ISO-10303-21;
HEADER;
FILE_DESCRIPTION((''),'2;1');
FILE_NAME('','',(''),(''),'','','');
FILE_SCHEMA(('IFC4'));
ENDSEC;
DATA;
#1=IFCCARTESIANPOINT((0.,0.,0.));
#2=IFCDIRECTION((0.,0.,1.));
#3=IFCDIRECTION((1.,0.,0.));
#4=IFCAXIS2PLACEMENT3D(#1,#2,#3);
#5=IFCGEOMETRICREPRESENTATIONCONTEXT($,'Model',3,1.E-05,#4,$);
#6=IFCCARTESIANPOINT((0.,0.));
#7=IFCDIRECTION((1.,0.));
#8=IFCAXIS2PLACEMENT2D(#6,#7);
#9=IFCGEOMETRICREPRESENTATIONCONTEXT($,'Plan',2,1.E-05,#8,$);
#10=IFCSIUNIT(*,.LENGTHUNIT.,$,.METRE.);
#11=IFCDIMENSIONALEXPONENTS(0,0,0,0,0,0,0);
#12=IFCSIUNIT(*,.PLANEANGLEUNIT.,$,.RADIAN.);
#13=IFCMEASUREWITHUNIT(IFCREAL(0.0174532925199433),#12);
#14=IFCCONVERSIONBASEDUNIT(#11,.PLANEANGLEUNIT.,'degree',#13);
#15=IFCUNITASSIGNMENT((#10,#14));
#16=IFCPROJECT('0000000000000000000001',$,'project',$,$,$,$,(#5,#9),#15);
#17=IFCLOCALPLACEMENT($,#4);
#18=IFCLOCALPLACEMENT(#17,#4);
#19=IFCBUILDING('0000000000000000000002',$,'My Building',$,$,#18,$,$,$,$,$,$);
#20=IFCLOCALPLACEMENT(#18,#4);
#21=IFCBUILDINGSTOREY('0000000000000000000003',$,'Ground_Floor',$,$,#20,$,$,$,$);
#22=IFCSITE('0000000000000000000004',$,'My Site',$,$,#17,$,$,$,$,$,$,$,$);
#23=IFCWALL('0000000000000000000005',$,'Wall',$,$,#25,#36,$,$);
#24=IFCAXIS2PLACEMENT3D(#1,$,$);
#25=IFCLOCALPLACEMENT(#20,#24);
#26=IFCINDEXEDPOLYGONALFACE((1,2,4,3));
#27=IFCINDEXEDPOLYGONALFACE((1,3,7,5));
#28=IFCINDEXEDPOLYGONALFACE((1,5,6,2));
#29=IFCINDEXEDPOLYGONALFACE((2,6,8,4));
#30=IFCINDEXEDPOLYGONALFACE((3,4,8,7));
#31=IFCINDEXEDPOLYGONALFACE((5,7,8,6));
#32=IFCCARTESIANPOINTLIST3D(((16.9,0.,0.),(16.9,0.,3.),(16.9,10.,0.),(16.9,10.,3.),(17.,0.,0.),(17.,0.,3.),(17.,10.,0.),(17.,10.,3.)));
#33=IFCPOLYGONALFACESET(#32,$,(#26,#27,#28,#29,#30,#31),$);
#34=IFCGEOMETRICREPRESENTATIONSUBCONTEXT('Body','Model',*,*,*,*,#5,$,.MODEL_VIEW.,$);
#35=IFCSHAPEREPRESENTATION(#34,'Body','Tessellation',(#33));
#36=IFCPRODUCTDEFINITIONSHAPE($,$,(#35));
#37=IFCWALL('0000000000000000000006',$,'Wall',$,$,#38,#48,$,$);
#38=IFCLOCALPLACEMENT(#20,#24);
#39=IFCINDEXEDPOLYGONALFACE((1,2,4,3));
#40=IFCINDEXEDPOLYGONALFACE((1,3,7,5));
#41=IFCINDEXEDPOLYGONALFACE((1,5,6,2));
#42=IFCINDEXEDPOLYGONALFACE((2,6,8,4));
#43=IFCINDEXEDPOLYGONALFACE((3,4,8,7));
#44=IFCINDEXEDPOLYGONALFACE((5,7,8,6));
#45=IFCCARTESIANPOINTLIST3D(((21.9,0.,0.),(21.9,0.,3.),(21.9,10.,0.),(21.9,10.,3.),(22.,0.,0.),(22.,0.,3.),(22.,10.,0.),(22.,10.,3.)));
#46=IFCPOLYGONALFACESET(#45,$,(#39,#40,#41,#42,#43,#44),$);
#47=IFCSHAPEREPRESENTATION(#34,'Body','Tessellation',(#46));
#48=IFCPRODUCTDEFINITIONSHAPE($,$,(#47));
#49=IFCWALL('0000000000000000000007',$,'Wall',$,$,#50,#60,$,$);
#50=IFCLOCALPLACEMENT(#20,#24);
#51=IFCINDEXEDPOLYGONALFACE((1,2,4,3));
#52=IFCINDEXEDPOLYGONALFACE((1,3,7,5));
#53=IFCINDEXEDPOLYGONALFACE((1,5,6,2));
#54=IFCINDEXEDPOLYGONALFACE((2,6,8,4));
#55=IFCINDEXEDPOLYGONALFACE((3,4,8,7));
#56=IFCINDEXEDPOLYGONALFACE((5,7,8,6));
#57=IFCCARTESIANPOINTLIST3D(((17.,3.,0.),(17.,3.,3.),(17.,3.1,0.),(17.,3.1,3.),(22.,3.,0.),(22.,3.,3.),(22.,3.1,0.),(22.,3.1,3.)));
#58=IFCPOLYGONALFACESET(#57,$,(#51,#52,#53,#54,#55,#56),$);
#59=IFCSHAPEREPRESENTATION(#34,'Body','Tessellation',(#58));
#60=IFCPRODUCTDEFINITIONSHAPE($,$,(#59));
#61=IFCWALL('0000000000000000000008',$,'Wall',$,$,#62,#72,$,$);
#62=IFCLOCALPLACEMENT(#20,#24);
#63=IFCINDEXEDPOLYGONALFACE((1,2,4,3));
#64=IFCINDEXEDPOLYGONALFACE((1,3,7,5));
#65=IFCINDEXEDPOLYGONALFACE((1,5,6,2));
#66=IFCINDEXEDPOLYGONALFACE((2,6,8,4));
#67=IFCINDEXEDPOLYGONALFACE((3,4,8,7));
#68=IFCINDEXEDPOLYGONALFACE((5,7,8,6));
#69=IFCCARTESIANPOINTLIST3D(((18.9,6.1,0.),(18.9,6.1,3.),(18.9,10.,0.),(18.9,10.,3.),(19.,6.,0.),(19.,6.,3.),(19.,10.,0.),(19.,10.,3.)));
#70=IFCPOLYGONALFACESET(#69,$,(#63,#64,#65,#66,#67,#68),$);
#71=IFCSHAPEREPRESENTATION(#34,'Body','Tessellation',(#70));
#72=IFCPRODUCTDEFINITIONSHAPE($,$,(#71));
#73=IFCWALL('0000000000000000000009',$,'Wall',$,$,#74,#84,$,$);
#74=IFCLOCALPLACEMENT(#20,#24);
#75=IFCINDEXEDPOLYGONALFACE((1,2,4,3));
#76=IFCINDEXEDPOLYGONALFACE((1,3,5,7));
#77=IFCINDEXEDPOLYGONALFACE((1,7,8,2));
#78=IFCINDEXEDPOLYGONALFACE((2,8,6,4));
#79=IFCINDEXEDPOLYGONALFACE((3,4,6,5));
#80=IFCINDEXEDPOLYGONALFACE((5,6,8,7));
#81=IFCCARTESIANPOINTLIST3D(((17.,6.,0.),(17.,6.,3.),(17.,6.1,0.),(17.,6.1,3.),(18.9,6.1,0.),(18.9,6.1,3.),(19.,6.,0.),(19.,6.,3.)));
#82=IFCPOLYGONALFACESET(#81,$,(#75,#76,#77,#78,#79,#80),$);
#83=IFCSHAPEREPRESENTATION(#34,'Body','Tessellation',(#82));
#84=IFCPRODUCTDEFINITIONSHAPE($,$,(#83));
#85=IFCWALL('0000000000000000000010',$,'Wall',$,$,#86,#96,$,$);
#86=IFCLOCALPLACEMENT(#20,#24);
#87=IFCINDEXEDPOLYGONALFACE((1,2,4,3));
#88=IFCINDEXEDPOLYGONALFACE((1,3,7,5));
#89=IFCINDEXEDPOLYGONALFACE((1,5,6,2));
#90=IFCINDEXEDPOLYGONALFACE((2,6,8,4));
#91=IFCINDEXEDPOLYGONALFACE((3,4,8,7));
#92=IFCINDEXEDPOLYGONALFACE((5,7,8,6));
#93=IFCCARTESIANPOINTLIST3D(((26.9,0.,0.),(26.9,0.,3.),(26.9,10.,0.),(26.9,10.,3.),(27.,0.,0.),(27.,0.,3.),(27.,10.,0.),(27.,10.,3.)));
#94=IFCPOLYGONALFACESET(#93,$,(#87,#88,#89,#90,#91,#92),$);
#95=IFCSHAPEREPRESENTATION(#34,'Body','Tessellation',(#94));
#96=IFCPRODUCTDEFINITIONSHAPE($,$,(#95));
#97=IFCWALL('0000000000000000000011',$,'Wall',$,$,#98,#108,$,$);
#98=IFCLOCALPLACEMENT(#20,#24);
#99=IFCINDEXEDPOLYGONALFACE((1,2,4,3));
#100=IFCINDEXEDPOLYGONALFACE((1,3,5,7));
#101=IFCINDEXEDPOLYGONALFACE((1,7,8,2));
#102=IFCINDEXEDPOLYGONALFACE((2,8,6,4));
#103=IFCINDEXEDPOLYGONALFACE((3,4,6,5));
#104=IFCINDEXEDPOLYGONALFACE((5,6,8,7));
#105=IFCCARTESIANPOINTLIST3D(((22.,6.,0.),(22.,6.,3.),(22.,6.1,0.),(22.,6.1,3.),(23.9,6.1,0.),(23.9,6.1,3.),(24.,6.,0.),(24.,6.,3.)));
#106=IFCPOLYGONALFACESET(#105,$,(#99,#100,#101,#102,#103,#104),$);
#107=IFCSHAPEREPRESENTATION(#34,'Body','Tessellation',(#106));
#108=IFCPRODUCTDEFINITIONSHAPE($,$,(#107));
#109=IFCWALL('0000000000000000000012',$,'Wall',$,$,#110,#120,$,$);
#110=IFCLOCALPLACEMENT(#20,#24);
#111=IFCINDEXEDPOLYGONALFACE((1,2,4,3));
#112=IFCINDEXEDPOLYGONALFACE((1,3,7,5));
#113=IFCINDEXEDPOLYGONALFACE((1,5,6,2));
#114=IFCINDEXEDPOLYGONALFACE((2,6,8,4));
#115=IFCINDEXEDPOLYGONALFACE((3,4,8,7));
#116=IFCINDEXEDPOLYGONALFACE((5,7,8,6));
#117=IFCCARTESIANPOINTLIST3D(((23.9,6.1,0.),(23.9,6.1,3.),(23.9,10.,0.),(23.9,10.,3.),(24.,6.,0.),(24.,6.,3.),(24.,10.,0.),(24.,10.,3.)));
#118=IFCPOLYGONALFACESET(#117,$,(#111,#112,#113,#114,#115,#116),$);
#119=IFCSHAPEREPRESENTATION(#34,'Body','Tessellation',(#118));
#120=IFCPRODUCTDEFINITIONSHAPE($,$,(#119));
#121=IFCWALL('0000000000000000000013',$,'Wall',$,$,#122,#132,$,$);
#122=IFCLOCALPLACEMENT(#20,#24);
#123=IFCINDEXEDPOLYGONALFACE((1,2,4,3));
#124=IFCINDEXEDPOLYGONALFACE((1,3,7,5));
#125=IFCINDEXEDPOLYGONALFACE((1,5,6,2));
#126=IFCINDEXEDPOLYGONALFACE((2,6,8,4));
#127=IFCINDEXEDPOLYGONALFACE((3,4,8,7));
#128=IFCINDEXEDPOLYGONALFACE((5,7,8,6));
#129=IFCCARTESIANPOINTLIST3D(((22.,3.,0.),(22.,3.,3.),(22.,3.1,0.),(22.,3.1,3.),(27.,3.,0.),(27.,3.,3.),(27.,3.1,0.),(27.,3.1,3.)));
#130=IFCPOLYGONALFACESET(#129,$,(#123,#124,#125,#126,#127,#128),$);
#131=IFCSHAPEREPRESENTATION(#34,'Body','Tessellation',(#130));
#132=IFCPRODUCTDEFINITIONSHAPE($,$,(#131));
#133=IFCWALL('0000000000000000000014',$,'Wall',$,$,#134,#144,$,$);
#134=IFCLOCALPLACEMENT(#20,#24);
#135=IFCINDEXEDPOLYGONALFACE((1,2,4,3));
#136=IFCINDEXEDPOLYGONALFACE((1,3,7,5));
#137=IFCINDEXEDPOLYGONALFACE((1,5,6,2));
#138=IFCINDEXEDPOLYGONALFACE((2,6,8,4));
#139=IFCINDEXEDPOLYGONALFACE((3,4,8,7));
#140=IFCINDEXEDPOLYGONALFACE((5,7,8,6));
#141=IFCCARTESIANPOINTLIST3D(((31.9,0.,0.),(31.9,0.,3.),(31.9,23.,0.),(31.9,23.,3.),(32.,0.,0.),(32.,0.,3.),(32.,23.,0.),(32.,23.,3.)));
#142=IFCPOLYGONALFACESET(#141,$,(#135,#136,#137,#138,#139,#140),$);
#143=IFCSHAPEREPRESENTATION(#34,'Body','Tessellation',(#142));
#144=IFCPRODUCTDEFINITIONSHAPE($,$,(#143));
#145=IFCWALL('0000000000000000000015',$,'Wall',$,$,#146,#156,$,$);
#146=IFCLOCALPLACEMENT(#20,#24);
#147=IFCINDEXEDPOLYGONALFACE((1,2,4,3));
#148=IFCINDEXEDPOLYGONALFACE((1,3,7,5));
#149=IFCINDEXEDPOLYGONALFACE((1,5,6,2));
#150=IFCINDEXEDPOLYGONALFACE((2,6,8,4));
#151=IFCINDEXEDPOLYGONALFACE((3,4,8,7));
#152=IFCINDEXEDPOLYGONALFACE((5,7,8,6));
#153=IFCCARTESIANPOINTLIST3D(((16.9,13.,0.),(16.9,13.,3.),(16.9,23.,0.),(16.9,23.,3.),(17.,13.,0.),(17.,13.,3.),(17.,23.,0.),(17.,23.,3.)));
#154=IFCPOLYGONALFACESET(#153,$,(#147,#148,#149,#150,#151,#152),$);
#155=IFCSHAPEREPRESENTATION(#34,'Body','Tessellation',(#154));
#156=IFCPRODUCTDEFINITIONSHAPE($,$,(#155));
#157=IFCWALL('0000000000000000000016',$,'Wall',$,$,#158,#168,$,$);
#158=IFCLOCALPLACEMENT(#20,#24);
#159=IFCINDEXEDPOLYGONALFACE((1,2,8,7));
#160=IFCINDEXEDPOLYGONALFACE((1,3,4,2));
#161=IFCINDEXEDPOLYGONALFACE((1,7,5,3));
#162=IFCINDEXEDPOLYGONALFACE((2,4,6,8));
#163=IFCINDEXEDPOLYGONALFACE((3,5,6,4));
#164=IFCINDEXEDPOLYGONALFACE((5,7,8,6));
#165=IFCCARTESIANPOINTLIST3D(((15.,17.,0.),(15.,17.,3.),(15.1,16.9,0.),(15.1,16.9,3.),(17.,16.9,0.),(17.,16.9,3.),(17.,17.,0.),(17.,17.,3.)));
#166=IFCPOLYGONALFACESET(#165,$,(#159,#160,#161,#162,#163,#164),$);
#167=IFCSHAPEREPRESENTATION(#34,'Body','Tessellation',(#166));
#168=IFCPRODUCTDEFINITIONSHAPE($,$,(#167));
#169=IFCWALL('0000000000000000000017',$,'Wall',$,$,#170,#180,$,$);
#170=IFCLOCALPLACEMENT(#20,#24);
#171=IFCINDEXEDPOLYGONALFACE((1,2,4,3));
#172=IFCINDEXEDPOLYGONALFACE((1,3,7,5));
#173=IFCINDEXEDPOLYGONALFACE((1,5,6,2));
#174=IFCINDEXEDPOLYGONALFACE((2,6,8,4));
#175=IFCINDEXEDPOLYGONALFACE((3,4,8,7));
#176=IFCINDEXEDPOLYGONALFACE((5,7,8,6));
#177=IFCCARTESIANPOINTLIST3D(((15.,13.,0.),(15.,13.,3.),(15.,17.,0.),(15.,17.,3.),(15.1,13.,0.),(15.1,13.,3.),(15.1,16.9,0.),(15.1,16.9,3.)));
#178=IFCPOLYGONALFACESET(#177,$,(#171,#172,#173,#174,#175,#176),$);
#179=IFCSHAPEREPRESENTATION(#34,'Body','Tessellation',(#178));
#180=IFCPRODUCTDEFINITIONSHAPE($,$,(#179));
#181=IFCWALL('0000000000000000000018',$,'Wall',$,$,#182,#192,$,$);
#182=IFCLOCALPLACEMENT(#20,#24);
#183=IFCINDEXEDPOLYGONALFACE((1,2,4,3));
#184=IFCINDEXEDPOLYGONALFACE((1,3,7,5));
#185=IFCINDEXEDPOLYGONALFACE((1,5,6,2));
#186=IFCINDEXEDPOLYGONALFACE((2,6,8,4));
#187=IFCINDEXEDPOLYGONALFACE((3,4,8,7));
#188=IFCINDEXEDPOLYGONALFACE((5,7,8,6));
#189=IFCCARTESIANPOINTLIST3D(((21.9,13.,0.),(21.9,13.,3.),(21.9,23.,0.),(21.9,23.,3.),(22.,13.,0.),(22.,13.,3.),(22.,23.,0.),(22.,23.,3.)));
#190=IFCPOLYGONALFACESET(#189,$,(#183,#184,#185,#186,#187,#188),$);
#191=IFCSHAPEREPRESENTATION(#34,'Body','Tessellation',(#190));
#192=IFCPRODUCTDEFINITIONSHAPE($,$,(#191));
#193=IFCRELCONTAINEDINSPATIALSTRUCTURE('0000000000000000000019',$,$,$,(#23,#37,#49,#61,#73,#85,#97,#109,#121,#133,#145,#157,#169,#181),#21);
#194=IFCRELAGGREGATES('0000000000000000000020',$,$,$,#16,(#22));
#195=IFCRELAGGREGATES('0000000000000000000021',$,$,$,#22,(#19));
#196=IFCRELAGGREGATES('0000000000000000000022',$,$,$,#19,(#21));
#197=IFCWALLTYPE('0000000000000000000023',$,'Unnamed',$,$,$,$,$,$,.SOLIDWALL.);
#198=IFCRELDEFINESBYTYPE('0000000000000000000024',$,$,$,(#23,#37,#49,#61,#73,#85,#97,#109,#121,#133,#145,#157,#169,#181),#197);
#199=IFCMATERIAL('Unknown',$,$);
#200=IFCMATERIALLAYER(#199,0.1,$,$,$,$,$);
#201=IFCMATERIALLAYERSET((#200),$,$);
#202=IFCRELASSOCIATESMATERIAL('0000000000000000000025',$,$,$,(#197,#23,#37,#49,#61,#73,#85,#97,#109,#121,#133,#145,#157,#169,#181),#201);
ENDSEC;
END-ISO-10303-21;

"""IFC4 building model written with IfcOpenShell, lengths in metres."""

from ifc_helpers import new_model, entity, si_unit, converted_unit, frame, origin_with_axes, origin_2d_with_axis, place, context, subcontext, project, spatial, line, indexed_curve, outline, extrude, material, layer, layer_set, layer_usage, type_object, element, save


model = new_model("IFC4")

# Units and contexts
model_context = context("Model", 3, precision=1e-05, world=origin_with_axes())
plan_context = context("Plan", 2, precision=1e-05, world=origin_2d_with_axis())
body_context = subcontext(model_context, "Body", "Model", "MODEL_VIEW")
ifc_project = project(units=[si_unit("LENGTHUNIT", "METRE"), converted_unit("PLANEANGLEUNIT", "degree", entity("IfcReal", 0.0174532925199433), si_unit("PLANEANGLEUNIT", "RADIAN"), dimensions=[0, 0, 0, 0, 0, 0, 0])], contexts=[model_context, plan_context])

# Site, building, storey
site_placement = place(None, origin_with_axes())
site = spatial("IfcSite", under=ifc_project, at=site_placement, Name="My Site")
building_placement = place(site_placement, origin_with_axes())
building = spatial("IfcBuilding", under=site, at=building_placement, Name="My Building")
storey_placement = place(building_placement, origin_with_axes())
storey = spatial("IfcBuildingStorey", under=building, at=storey_placement, Name="Ground_Floor")

# Walls
ifc_material = material(Name="Unknown")
ifc_layer = layer(ifc_material, 0.1)
ifc_layer_set = layer_set([ifc_layer])
ifc_layer_usage_1 = layer_usage(ifc_layer_set, "AXIS2", "POSITIVE", 0.0)
wall_type = type_object("IfcWallType", Name="Unnamed", PredefinedType="SOLIDWALL", material=ifc_layer_set)
wall_1_placement = place(storey_placement, frame((17.0, 0.0, 0.0), z_axis=(0.0, 0.0, 1.0), x_axis=(0.0, 1.0, 0.0)))
element("IfcWall", 1, at=wall_1_placement, inside=storey, type_object=wall_type, material=ifc_layer_usage_1, Name="Wall", context=body_context, shape_type="SweptSolid", body=[
    extrude(outline(indexed_curve([(0.0, 0.0), (0.0, 0.1), (10.0, 0.1), (10.0, 0.0)], segments=[line(1, 2, 3, 4, 1)])), origin_with_axes(), (0.0, 0.0, 1.0), 3.0),
])
ifc_layer_usage_2 = layer_usage(ifc_layer_set, "AXIS2", "POSITIVE", 0.0)
wall_2_placement = place(storey_placement, frame((22.0, 0.0, 0.0), z_axis=(0.0, 0.0, 1.0), x_axis=(0.0, 1.0, 0.0)))
element("IfcWall", 2, at=wall_2_placement, inside=storey, type_object=wall_type, material=ifc_layer_usage_2, Name="Wall", context=body_context, shape_type="SweptSolid", body=[
    extrude(outline(indexed_curve([(0.0, 0.0), (0.0, 0.1), (10.0, 0.1), (10.0, 0.0)], segments=[line(1, 2, 3, 4, 1)])), origin_with_axes(), (0.0, 0.0, 1.0), 3.0),
])
ifc_layer_usage_3 = layer_usage(ifc_layer_set, "AXIS2", "POSITIVE", 0.0)
wall_3_placement = place(storey_placement, frame((17.0, 3.0, 0.0), z_axis=(0.0, 0.0, 1.0), x_axis=(1.0, 0.0, 0.0)))
element("IfcWall", 3, at=wall_3_placement, inside=storey, type_object=wall_type, material=ifc_layer_usage_3, Name="Wall", context=body_context, shape_type="SweptSolid", body=[
    extrude(outline(indexed_curve([(0.0, 0.0), (0.0, 0.1), (5.0, 0.1), (5.0, 0.0)], segments=[line(1, 2, 3, 4, 1)])), origin_with_axes(), (0.0, 0.0, 1.0), 3.0),
])
ifc_layer_usage_4 = layer_usage(ifc_layer_set, "AXIS2", "POSITIVE", 0.0)
wall_4_placement = place(storey_placement, frame((19.0, 6.0, 0.0), z_axis=(0.0, 0.0, 1.0), x_axis=(0.0, 1.0, 0.0)))
element("IfcWall", 4, at=wall_4_placement, inside=storey, type_object=wall_type, material=ifc_layer_usage_4, Name="Wall", context=body_context, shape_type="SweptSolid", body=[
    extrude(outline(indexed_curve([(0.0, 0.0), (0.1, 0.1), (4.0, 0.1), (4.0, 0.0)], segments=[line(1, 2, 3, 4, 1)])), origin_with_axes(), (0.0, 0.0, 1.0), 3.0),
])
ifc_layer_usage_5 = layer_usage(ifc_layer_set, "AXIS2", "POSITIVE", 0.0)
wall_5_placement = place(storey_placement, frame((17.0, 6.0, 0.0), z_axis=(0.0, 0.0, 1.0), x_axis=(1.0, 0.0, 0.0)))
element("IfcWall", 5, at=wall_5_placement, inside=storey, type_object=wall_type, material=ifc_layer_usage_5, Name="Wall", context=body_context, shape_type="SweptSolid", body=[
    extrude(outline(indexed_curve([(0.0, 0.0), (0.0, 0.1), (1.9, 0.1), (2.0, 0.0)], segments=[line(1, 2, 3, 4, 1)])), origin_with_axes(), (0.0, 0.0, 1.0), 3.0),
])
ifc_layer_usage_6 = layer_usage(ifc_layer_set, "AXIS2", "POSITIVE", 0.0)
wall_6_placement = place(storey_placement, frame((27.0, 0.0, 0.0), z_axis=(0.0, 0.0, 1.0), x_axis=(0.0, 1.0, 0.0)))
element("IfcWall", 6, at=wall_6_placement, inside=storey, type_object=wall_type, material=ifc_layer_usage_6, Name="Wall", context=body_context, shape_type="SweptSolid", body=[
    extrude(outline(indexed_curve([(0.0, 0.0), (0.0, 0.1), (10.0, 0.1), (10.0, 0.0)], segments=[line(1, 2, 3, 4, 1)])), origin_with_axes(), (0.0, 0.0, 1.0), 3.0),
])
ifc_layer_usage_7 = layer_usage(ifc_layer_set, "AXIS2", "POSITIVE", 0.0)
wall_7_placement = place(storey_placement, frame((22.0, 6.0, 0.0), z_axis=(0.0, 0.0, 1.0), x_axis=(1.0, 0.0, 0.0)))
element("IfcWall", 7, at=wall_7_placement, inside=storey, type_object=wall_type, material=ifc_layer_usage_7, Name="Wall", context=body_context, shape_type="SweptSolid", body=[
    extrude(outline(indexed_curve([(0.0, 0.0), (0.0, 0.1), (1.9, 0.1), (2.0, 0.0)], segments=[line(1, 2, 3, 4, 1)])), origin_with_axes(), (0.0, 0.0, 1.0), 3.0),
])
ifc_layer_usage_8 = layer_usage(ifc_layer_set, "AXIS2", "POSITIVE", 0.0)
wall_8_placement = place(storey_placement, frame((24.0, 6.0, 0.0), z_axis=(0.0, 0.0, 1.0), x_axis=(0.0, 1.0, 0.0)))
element("IfcWall", 8, at=wall_8_placement, inside=storey, type_object=wall_type, material=ifc_layer_usage_8, Name="Wall", context=body_context, shape_type="SweptSolid", body=[
    extrude(outline(indexed_curve([(0.0, 0.0), (0.1, 0.1), (4.0, 0.1), (4.0, 0.0)], segments=[line(1, 2, 3, 4, 1)])), origin_with_axes(), (0.0, 0.0, 1.0), 3.0),
])
ifc_layer_usage_9 = layer_usage(ifc_layer_set, "AXIS2", "POSITIVE", 0.0)
wall_9_placement = place(storey_placement, frame((22.0, 3.0, 0.0), z_axis=(0.0, 0.0, 1.0), x_axis=(1.0, 0.0, 0.0)))
element("IfcWall", 9, at=wall_9_placement, inside=storey, type_object=wall_type, material=ifc_layer_usage_9, Name="Wall", context=body_context, shape_type="SweptSolid", body=[
    extrude(outline(indexed_curve([(0.0, 0.0), (0.0, 0.1), (5.0, 0.1), (5.0, 0.0)], segments=[line(1, 2, 3, 4, 1)])), origin_with_axes(), (0.0, 0.0, 1.0), 3.0),
])
ifc_layer_usage_10 = layer_usage(ifc_layer_set, "AXIS2", "POSITIVE", 0.0)
wall_10_placement = place(storey_placement, frame((32.0, 0.0, 0.0), z_axis=(0.0, 0.0, 1.0), x_axis=(0.0, 1.0, 0.0)))
element("IfcWall", 10, at=wall_10_placement, inside=storey, type_object=wall_type, material=ifc_layer_usage_10, Name="Wall", context=body_context, shape_type="SweptSolid", body=[
    extrude(outline(indexed_curve([(0.0, 0.0), (0.0, 0.1), (23.0, 0.1), (23.0, 0.0)], segments=[line(1, 2, 3, 4, 1)])), origin_with_axes(), (0.0, 0.0, 1.0), 3.0),
])
ifc_layer_usage_11 = layer_usage(ifc_layer_set, "AXIS2", "POSITIVE", 0.0)
wall_11_placement = place(storey_placement, frame((17.0, 13.0, 0.0), z_axis=(0.0, 0.0, 1.0), x_axis=(0.0, 1.0, 0.0)))
element("IfcWall", 11, at=wall_11_placement, inside=storey, type_object=wall_type, material=ifc_layer_usage_11, Name="Wall", context=body_context, shape_type="SweptSolid", body=[
    extrude(outline(indexed_curve([(0.0, 0.0), (0.0, 0.1), (10.0, 0.1), (10.0, 0.0)], segments=[line(1, 2, 3, 4, 1)])), origin_with_axes(), (0.0, 0.0, 1.0), 3.0),
])
ifc_layer_usage_12 = layer_usage(ifc_layer_set, "AXIS2", "POSITIVE", 0.0)
wall_12_placement = place(storey_placement, frame((17.0, 17.0, 0.0), z_axis=(0.0, 0.0, 1.0), x_axis=(-1.0, 0.0, 0.0)))
element("IfcWall", 12, at=wall_12_placement, inside=storey, type_object=wall_type, material=ifc_layer_usage_12, Name="Wall", context=body_context, shape_type="SweptSolid", body=[
    extrude(outline(indexed_curve([(0.0, 0.0), (0.0, 0.1), (1.9, 0.1), (2.0, 0.0)], segments=[line(1, 2, 3, 4, 1)])), origin_with_axes(), (0.0, 0.0, 1.0), 3.0),
])
ifc_layer_usage_13 = layer_usage(ifc_layer_set, "AXIS2", "POSITIVE", 0.0)
wall_13_placement = place(storey_placement, frame((15.0, 17.0, 0.0), z_axis=(0.0, 0.0, 1.0), x_axis=(0.0, -1.0, 0.0)))
element("IfcWall", 13, at=wall_13_placement, inside=storey, type_object=wall_type, material=ifc_layer_usage_13, Name="Wall", context=body_context, shape_type="SweptSolid", body=[
    extrude(outline(indexed_curve([(0.0, 0.0), (0.1, 0.1), (4.0, 0.1), (4.0, 0.0)], segments=[line(1, 2, 3, 4, 1)])), origin_with_axes(), (0.0, 0.0, 1.0), 3.0),
])
ifc_layer_usage_14 = layer_usage(ifc_layer_set, "AXIS2", "POSITIVE", 0.0)
wall_14_placement = place(storey_placement, frame((22.0, 13.0, 0.0), z_axis=(0.0, 0.0, 1.0), x_axis=(0.0, 1.0, 0.0)))
element("IfcWall", 14, at=wall_14_placement, inside=storey, type_object=wall_type, material=ifc_layer_usage_14, Name="Wall", context=body_context, shape_type="SweptSolid", body=[
    extrude(outline(indexed_curve([(0.0, 0.0), (0.0, 0.1), (10.0, 0.1), (10.0, 0.0)], segments=[line(1, 2, 3, 4, 1)])), origin_with_axes(), (0.0, 0.0, 1.0), 3.0),
])

save(model, "model.ifc")
